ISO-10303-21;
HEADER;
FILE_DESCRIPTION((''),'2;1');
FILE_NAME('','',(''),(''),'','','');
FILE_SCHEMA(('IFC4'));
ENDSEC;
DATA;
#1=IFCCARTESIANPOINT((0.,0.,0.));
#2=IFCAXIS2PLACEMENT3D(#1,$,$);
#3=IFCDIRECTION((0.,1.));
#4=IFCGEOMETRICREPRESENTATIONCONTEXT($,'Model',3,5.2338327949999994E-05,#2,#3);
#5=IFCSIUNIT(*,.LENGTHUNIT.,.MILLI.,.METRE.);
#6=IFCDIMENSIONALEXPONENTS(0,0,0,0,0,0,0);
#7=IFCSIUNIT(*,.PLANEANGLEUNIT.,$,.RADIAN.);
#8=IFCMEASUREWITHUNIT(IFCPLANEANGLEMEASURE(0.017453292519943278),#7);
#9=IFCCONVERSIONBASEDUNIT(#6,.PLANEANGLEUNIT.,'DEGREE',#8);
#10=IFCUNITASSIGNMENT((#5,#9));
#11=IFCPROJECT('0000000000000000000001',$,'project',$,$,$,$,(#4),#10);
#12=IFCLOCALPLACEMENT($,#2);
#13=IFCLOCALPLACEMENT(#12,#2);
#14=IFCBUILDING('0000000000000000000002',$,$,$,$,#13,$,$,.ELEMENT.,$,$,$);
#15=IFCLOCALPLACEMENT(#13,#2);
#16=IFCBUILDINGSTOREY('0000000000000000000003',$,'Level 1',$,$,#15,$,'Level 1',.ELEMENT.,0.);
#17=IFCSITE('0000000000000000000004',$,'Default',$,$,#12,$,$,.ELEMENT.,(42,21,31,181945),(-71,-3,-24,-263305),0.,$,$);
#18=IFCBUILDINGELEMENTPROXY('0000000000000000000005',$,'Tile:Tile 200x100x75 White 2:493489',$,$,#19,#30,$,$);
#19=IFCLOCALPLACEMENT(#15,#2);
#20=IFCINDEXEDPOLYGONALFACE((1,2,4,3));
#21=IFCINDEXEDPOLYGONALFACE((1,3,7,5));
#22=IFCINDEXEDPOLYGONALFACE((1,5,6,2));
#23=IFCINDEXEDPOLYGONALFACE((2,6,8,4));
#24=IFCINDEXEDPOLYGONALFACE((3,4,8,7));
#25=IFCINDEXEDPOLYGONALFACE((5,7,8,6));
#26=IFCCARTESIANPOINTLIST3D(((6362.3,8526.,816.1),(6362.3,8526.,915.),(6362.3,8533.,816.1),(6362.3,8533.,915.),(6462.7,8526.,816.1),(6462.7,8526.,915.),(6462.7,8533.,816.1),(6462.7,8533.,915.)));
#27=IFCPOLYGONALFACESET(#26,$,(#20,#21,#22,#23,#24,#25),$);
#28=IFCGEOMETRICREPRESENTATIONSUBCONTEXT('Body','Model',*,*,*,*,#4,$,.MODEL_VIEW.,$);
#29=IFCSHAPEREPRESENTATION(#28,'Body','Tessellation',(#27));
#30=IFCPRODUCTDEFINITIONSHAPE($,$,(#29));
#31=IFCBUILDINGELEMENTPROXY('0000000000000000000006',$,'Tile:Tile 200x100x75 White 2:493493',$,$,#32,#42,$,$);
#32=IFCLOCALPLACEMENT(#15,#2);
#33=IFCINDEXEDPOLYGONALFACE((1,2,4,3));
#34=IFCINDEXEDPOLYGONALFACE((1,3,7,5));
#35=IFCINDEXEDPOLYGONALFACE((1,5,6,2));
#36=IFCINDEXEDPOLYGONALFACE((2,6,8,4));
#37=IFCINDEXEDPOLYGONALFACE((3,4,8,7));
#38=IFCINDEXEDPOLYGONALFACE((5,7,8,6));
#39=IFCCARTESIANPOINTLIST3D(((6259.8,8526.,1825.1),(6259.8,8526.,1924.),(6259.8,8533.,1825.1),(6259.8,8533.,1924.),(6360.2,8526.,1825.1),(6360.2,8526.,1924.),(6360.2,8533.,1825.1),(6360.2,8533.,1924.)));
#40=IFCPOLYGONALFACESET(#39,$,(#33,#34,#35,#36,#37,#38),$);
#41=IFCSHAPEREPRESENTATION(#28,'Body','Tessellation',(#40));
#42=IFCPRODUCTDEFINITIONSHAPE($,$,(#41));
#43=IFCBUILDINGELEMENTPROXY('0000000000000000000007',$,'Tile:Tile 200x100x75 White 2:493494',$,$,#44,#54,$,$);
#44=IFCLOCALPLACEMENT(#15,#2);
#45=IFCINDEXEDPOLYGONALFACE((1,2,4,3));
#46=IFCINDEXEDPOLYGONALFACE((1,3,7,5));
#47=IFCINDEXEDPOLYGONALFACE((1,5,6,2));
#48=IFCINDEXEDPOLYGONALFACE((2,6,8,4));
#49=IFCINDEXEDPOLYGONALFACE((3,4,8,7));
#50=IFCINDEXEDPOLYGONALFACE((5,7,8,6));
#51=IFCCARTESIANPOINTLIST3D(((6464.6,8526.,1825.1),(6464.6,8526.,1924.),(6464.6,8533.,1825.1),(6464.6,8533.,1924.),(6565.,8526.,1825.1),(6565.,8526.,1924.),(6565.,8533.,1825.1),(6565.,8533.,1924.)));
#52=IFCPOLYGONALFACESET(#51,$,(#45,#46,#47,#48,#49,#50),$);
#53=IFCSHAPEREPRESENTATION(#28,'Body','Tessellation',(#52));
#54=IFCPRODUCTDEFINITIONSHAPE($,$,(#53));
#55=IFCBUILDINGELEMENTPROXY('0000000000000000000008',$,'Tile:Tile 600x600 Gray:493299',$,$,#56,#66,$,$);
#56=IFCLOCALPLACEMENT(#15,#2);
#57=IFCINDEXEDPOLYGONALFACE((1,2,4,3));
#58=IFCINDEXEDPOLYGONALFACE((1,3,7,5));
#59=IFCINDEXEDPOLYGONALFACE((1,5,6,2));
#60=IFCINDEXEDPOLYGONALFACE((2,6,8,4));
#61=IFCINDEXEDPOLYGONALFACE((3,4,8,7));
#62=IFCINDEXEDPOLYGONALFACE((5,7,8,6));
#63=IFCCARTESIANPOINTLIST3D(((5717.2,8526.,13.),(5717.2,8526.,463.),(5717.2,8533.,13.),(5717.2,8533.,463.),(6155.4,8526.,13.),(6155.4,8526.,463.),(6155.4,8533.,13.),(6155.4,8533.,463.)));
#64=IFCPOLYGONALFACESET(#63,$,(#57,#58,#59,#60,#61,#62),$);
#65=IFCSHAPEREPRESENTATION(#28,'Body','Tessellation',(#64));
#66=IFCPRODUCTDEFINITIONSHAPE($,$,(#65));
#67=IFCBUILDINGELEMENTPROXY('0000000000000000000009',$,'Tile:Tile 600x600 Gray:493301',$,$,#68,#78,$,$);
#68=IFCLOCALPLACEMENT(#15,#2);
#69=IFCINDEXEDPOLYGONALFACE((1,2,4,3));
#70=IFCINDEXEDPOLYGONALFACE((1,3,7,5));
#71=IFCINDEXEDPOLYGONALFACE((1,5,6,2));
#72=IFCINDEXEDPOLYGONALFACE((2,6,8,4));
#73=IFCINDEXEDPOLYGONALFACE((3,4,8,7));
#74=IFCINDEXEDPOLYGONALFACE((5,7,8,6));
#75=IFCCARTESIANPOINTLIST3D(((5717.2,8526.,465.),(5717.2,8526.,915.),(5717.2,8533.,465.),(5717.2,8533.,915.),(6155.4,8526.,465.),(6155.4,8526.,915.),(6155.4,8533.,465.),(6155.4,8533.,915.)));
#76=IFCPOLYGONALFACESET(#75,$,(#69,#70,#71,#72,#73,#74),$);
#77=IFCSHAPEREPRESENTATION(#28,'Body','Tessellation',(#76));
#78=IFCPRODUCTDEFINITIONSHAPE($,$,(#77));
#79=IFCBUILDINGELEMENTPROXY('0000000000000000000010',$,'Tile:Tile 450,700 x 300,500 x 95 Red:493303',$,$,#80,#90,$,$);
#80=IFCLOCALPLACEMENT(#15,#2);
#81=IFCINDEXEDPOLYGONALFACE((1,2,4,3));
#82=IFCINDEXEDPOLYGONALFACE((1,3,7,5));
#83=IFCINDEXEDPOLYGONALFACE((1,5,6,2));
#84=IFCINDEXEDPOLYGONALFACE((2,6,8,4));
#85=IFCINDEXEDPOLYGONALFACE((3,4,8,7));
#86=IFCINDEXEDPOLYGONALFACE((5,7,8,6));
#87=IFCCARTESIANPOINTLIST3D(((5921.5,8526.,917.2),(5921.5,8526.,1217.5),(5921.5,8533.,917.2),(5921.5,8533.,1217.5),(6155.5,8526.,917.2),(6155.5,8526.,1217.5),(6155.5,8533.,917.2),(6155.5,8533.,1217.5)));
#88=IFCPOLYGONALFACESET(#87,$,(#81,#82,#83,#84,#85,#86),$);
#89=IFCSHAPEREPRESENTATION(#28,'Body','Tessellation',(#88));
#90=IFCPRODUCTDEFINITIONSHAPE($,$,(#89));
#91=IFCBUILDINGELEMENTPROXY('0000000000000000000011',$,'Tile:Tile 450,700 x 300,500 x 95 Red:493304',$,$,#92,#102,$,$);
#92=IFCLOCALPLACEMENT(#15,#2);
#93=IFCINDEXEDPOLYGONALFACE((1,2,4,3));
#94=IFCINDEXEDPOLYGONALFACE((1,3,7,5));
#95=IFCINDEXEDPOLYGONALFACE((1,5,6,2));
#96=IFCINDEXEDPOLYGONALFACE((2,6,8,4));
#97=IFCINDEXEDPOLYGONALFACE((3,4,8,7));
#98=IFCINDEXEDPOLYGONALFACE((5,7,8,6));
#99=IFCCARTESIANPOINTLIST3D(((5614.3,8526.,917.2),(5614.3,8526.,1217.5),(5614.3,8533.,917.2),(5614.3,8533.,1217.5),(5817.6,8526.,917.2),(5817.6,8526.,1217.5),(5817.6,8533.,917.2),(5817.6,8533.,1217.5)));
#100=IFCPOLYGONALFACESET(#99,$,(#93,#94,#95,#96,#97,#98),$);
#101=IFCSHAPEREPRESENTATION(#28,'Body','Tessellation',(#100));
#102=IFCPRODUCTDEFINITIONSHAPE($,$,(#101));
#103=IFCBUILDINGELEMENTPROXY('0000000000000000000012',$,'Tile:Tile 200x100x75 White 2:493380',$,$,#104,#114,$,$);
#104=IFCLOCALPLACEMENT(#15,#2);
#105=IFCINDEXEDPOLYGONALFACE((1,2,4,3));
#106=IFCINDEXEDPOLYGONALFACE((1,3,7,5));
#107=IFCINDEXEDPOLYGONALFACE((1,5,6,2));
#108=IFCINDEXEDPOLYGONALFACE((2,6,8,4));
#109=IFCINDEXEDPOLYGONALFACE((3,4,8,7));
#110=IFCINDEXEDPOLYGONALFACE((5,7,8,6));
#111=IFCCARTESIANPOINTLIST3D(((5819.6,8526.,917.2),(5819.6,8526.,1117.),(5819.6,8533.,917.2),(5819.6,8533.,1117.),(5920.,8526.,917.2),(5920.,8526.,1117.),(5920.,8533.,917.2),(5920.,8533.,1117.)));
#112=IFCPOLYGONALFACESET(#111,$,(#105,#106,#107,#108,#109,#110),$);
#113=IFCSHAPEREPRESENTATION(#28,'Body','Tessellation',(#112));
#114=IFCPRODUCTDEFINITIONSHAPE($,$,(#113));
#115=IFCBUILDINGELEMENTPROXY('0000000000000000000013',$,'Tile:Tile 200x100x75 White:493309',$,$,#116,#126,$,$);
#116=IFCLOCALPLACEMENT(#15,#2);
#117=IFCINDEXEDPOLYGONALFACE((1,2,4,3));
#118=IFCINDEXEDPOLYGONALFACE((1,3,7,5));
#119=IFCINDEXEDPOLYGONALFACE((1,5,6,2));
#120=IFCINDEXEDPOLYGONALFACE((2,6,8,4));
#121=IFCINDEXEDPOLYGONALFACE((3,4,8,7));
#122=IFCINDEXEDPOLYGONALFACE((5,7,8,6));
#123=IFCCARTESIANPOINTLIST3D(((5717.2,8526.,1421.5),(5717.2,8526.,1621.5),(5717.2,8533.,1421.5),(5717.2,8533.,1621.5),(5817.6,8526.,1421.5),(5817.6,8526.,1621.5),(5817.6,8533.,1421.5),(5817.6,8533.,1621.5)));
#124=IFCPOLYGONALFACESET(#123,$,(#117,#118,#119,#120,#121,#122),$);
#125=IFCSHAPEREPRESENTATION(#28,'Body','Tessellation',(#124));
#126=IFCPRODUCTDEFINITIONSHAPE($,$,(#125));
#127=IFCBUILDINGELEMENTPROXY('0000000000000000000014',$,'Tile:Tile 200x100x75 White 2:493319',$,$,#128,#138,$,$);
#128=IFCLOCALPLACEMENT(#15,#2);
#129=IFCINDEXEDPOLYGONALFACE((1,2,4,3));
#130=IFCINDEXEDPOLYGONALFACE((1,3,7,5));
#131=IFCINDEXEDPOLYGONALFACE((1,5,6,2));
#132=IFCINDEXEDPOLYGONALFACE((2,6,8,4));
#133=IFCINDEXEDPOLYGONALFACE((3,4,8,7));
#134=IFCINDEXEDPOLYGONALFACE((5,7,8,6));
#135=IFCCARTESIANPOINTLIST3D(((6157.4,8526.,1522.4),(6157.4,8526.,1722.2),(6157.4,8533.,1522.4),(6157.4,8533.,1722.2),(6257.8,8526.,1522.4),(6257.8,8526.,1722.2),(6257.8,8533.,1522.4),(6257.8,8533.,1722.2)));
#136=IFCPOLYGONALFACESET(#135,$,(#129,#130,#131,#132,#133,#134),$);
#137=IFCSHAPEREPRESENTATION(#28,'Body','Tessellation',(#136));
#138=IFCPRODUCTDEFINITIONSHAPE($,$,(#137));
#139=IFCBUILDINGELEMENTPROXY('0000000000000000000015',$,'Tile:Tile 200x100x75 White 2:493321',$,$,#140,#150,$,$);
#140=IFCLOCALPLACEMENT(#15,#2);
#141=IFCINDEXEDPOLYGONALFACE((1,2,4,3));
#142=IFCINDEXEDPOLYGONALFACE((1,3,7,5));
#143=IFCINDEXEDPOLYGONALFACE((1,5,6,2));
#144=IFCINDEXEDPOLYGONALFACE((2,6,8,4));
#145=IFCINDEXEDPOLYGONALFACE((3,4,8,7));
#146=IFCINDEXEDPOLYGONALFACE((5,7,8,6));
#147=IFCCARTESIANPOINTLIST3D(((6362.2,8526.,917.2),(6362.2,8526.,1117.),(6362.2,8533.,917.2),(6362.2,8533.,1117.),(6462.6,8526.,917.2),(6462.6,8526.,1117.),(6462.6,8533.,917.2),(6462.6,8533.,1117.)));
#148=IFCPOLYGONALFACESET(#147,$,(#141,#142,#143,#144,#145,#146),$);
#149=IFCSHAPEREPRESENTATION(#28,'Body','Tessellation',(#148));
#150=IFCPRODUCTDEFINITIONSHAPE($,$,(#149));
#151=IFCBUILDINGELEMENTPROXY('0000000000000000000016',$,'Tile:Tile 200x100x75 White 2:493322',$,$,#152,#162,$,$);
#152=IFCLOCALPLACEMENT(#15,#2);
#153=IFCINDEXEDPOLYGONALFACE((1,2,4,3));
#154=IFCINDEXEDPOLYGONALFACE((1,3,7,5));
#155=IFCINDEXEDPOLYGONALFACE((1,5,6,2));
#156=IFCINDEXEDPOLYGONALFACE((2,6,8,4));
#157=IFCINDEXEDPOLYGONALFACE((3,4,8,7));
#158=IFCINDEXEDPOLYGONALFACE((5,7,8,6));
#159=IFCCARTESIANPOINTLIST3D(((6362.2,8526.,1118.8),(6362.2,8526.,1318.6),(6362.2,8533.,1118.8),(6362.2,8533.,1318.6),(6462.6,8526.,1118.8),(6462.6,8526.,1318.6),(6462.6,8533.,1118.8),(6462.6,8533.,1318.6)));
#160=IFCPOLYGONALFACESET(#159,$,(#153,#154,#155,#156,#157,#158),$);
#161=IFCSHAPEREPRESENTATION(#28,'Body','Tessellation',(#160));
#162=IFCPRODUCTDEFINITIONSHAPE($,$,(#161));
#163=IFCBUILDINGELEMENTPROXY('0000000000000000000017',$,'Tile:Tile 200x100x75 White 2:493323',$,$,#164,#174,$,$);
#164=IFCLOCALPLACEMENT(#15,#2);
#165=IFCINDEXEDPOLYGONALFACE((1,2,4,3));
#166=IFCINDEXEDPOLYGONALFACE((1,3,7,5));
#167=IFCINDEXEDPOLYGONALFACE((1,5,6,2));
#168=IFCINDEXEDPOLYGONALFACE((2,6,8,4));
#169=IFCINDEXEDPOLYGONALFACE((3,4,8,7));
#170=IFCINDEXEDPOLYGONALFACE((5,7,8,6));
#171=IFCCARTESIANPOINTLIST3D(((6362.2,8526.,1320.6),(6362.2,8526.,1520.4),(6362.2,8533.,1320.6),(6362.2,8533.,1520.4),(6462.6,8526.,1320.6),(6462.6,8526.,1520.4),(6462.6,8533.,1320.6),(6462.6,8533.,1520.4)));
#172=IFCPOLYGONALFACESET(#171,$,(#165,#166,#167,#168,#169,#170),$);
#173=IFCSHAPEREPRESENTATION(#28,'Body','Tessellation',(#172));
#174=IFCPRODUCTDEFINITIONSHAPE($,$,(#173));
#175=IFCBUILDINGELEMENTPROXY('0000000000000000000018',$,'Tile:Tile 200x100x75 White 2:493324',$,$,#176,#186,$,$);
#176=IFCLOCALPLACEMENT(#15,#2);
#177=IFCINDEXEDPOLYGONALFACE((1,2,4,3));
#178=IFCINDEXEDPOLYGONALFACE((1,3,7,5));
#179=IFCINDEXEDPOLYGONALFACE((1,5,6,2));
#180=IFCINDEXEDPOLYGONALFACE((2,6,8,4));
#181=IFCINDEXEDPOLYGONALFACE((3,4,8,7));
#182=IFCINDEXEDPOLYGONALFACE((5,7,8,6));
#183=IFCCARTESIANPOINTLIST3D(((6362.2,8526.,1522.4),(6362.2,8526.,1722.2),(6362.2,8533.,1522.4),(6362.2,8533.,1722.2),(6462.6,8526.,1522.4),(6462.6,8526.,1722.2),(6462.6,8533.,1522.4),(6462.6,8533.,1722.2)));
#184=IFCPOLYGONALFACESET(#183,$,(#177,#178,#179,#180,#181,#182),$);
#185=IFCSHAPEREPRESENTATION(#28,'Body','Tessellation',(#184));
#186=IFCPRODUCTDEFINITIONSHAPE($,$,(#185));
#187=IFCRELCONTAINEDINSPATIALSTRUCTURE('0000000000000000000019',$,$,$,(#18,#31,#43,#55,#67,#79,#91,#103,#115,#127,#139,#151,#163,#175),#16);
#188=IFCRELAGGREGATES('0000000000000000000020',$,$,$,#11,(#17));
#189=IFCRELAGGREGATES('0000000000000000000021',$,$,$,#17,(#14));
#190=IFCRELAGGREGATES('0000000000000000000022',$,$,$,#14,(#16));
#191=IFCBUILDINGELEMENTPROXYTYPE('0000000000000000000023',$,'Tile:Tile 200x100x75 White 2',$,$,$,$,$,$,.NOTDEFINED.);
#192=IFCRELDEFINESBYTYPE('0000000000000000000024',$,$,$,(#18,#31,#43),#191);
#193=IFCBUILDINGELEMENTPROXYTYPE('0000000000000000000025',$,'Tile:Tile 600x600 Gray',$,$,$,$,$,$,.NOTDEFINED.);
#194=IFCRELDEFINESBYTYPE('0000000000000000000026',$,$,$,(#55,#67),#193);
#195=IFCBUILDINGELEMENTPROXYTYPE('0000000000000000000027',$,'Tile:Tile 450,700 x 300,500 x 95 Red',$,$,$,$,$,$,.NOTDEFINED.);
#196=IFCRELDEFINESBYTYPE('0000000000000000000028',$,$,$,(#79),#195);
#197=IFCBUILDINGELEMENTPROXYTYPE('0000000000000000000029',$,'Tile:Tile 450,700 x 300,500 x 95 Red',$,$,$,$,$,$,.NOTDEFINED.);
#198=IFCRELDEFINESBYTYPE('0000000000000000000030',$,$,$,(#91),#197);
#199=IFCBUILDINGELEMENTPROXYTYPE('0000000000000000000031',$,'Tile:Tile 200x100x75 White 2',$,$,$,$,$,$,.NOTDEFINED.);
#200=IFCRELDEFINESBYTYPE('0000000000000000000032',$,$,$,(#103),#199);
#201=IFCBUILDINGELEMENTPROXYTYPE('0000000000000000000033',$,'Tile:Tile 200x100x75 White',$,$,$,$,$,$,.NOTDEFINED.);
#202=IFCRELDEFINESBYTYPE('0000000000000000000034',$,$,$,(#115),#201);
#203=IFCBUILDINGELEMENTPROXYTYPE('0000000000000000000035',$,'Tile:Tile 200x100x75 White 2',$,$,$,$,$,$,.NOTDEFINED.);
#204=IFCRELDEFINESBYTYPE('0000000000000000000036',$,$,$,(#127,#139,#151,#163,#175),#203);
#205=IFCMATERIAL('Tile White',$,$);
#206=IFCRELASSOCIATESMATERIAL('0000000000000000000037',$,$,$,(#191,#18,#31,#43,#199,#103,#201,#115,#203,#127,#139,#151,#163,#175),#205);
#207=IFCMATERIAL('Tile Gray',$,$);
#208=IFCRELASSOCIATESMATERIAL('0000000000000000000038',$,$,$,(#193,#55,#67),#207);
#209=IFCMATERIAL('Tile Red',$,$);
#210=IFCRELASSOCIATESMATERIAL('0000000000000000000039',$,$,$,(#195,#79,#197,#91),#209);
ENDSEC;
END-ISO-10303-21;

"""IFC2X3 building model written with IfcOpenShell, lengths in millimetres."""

from ifc_helpers import new_model, entity, si_unit, converted_unit, direction, frame, frame_2d, origin, origin_2d_with_axis, place, context, subcontext, project, spatial, rectangle, extrude, source, transform, mapped, material, type_object, type_shapes, element, save


model = new_model("IFC2X3")

# Units and contexts
model_context = context("Model", 3, precision=5.2338327949999994e-05, world=origin(), true_north=direction((0.0, 1.0)))
body_context = subcontext(model_context, "Body", "Model", "MODEL_VIEW")
ifc_project = project(units=[si_unit("LENGTHUNIT", "METRE", prefix="MILLI"), converted_unit("PLANEANGLEUNIT", "DEGREE", entity("IfcPlaneAngleMeasure", 0.017453292519943278), si_unit("PLANEANGLEUNIT", "RADIAN"), dimensions=[0, 0, 0, 0, 0, 0, 0])], contexts=[model_context])

# Site, building, storey
site_placement = place(None, origin())
site = spatial("IfcSite", under=ifc_project, at=site_placement, Name="Default", CompositionType="ELEMENT", RefLatitude=(42, 21, 31, 181945), RefLongitude=(-71, -3, -24, -263305), RefElevation=0.0)
building_placement = place(site_placement, origin())
building = spatial("IfcBuilding", under=site, at=building_placement, CompositionType="ELEMENT")
storey_placement = place(building_placement, origin())
storey = spatial("IfcBuildingStorey", under=building, at=storey_placement, Name="Level 1", LongName="Level 1", CompositionType="ELEMENT", Elevation=0.0)

# Building element proxies
ifc_material_1 = material(Name="Tile White")
building_element_proxy_type_1 = type_object("IfcBuildingElementProxyType", Name="Tile:Tile 200x100x75 White 2", PredefinedType="NOTDEFINED", material=ifc_material_1)
shared_shape_1 = source(origin(), body_context, "Body", "SweptSolid", [
    extrude(rectangle(XDim=98.9, YDim=100.4, at=origin_2d_with_axis()), frame((-50.2, -49.5, 0.0), z_axis=(0.0, 0.0, 1.0), x_axis=(0.0, -1.0, 0.0)), (0.0, 0.0, 1.0), 7.0),
])
type_shapes(building_element_proxy_type_1, [shared_shape_1])
for number, where, z_axis, x_axis, name in (
    (1, (6462.7, 8533.0, 915.0), (0.0, -1.0, 0.0), (1.0, 0.0, 0.0), "Tile:Tile 200x100x75 White 2:493489"),
    (2, (6360.2, 8533.0, 1924.0), (0.0, -1.0, 0.0), (1.0, 0.0, 0.0), "Tile:Tile 200x100x75 White 2:493493"),
    (3, (6565.0, 8533.0, 1924.0), (0.0, -1.0, 0.0), (1.0, 0.0, 0.0), "Tile:Tile 200x100x75 White 2:493494"),
):
    element("IfcBuildingElementProxy", number, at=place(storey_placement, frame(where, z_axis=z_axis, x_axis=x_axis)), inside=storey, type_object=building_element_proxy_type_1, material=ifc_material_1, Name=name, context=body_context, shape_type="MappedRepresentation", body=[
        mapped(shared_shape_1, transform((0.0, 0.0, 0.0), scale=1.0)),
    ])
ifc_material_2 = material(Name="Tile Gray")
building_element_proxy_type_2 = type_object("IfcBuildingElementProxyType", Name="Tile:Tile 600x600 Gray", PredefinedType="NOTDEFINED", material=ifc_material_2)
shared_shape_2 = source(origin(), body_context, "Body", "SweptSolid", [
    extrude(rectangle(XDim=438.2, YDim=450.0, at=origin_2d_with_axis()), frame((-219.1, -225.0, 0.0), z_axis=(0.0, 0.0, 1.0), x_axis=(-1.0, 0.0, 0.0)), (0.0, 0.0, 1.0), 7.0),
])
type_shapes(building_element_proxy_type_2, [shared_shape_2])
for number, where, z_axis, x_axis, name in (
    (4, (6155.4, 8533.0, 463.0), (0.0, -1.0, 0.0), (1.0, 0.0, 0.0), "Tile:Tile 600x600 Gray:493299"),
    (5, (6155.4, 8533.0, 915.0), (0.0, -1.0, 0.0), (1.0, 0.0, 0.0), "Tile:Tile 600x600 Gray:493301"),
):
    element("IfcBuildingElementProxy", number, at=place(storey_placement, frame(where, z_axis=z_axis, x_axis=x_axis)), inside=storey, type_object=building_element_proxy_type_2, material=ifc_material_2, Name=name, context=body_context, shape_type="MappedRepresentation", body=[
        mapped(shared_shape_2, transform((0.0, 0.0, 0.0), scale=1.0)),
    ])
ifc_material_3 = material(Name="Tile Red")
building_element_proxy_type_3 = type_object("IfcBuildingElementProxyType", Name="Tile:Tile 450,700 x 300,500 x 95 Red", PredefinedType="NOTDEFINED", material=ifc_material_3)
shared_shape_3 = source(origin(), body_context, "Body", "SweptSolid", [
    extrude(rectangle(XDim=233.9, YDim=300.3, at=frame_2d((0.0, 0.0), x_axis=(1.0, 0.0))), frame((-117.0, -150.2, 0.0), z_axis=(0.0, 0.0, 1.0), x_axis=(-1.0, 0.0, 0.0)), (0.0, 0.0, 1.0), 7.0),
])
type_shapes(building_element_proxy_type_3, [shared_shape_3])
proxy_1_placement = place(storey_placement, frame((6155.5, 8533.0, 1217.5), z_axis=(0.0, -1.0, 0.0), x_axis=(1.0, 0.0, 0.0)))
element("IfcBuildingElementProxy", 6, at=proxy_1_placement, inside=storey, type_object=building_element_proxy_type_3, material=ifc_material_3, Name="Tile:Tile 450,700 x 300,500 x 95 Red:493303", context=body_context, shape_type="MappedRepresentation", body=[
    mapped(shared_shape_3, transform((0.0, 0.0, 0.0), scale=1.0)),
])
building_element_proxy_type_4 = type_object("IfcBuildingElementProxyType", Name="Tile:Tile 450,700 x 300,500 x 95 Red", PredefinedType="NOTDEFINED", material=ifc_material_3)
shared_shape_4 = source(origin(), body_context, "Body", "SweptSolid", [
    extrude(rectangle(XDim=203.3, YDim=300.3, at=frame_2d((0.0, 0.0), x_axis=(1.0, 0.0))), frame((-101.6, -150.2, 0.0), z_axis=(0.0, 0.0, 1.0), x_axis=(-1.0, 0.0, 0.0)), (0.0, 0.0, 1.0), 7.0),
])
type_shapes(building_element_proxy_type_4, [shared_shape_4])
proxy_2_placement = place(storey_placement, frame((5817.6, 8533.0, 1217.5), z_axis=(0.0, -1.0, 0.0), x_axis=(1.0, 0.0, 0.0)))
element("IfcBuildingElementProxy", 7, at=proxy_2_placement, inside=storey, type_object=building_element_proxy_type_4, material=ifc_material_3, Name="Tile:Tile 450,700 x 300,500 x 95 Red:493304", context=body_context, shape_type="MappedRepresentation", body=[
    mapped(shared_shape_4, transform((0.0, 0.0, 0.0), scale=1.0)),
])
building_element_proxy_type_5 = type_object("IfcBuildingElementProxyType", Name="Tile:Tile 200x100x75 White 2", PredefinedType="NOTDEFINED", material=ifc_material_1)
shared_shape_5 = source(origin(), body_context, "Body", "SweptSolid", [
    extrude(rectangle(XDim=199.8, YDim=100.4, at=frame_2d((0.0, 0.0), x_axis=(1.0, 0.0))), frame((-50.2, -99.9, 0.0), z_axis=(0.0, 0.0, 1.0), x_axis=(0.0, -1.0, 0.0)), (0.0, 0.0, 1.0), 7.0),
])
type_shapes(building_element_proxy_type_5, [shared_shape_5])
proxy_3_placement = place(storey_placement, frame((5920.0, 8533.0, 1117.0), z_axis=(0.0, -1.0, 0.0), x_axis=(1.0, 0.0, 0.0)))
element("IfcBuildingElementProxy", 8, at=proxy_3_placement, inside=storey, type_object=building_element_proxy_type_5, material=ifc_material_1, Name="Tile:Tile 200x100x75 White 2:493380", context=body_context, shape_type="MappedRepresentation", body=[
    mapped(shared_shape_5, transform((0.0, 0.0, 0.0), scale=1.0)),
])
building_element_proxy_type_6 = type_object("IfcBuildingElementProxyType", Name="Tile:Tile 200x100x75 White", PredefinedType="NOTDEFINED", material=ifc_material_1)
shared_shape_6 = source(origin(), body_context, "Body", "SweptSolid", [
    extrude(rectangle(XDim=200.0, YDim=100.4, at=frame_2d((0.0, 0.0), x_axis=(1.0, 0.0))), frame((-50.2, -100.0, 0.0), z_axis=(0.0, 0.0, 1.0), x_axis=(0.0, -1.0, 0.0)), (0.0, 0.0, 1.0), 7.0),
])
type_shapes(building_element_proxy_type_6, [shared_shape_6])
proxy_4_placement = place(storey_placement, frame((5817.6, 8533.0, 1621.5), z_axis=(0.0, -1.0, 0.0), x_axis=(1.0, 0.0, 0.0)))
element("IfcBuildingElementProxy", 9, at=proxy_4_placement, inside=storey, type_object=building_element_proxy_type_6, material=ifc_material_1, Name="Tile:Tile 200x100x75 White:493309", context=body_context, shape_type="MappedRepresentation", body=[
    mapped(shared_shape_6, transform((0.0, 0.0, 0.0), scale=1.0)),
])
building_element_proxy_type_7 = type_object("IfcBuildingElementProxyType", Name="Tile:Tile 200x100x75 White 2", PredefinedType="NOTDEFINED", material=ifc_material_1)
shared_shape_7 = source(origin(), body_context, "Body", "SweptSolid", [
    extrude(rectangle(XDim=199.8, YDim=100.4, at=frame_2d((0.0, 0.0), x_axis=(1.0, 0.0))), frame((-50.2, -99.9, 0.0), z_axis=(0.0, 0.0, 1.0), x_axis=(0.0, -1.0, 0.0)), (0.0, 0.0, 1.0), 7.0),
])
type_shapes(building_element_proxy_type_7, [shared_shape_7])
for number, where, z_axis, x_axis, name in (
    (10, (6257.8, 8533.0, 1722.2), (0.0, -1.0, 0.0), (1.0, 0.0, 0.0), "Tile:Tile 200x100x75 White 2:493319"),
    (11, (6462.6, 8533.0, 1117.0), (0.0, -1.0, 0.0), (1.0, 0.0, 0.0), "Tile:Tile 200x100x75 White 2:493321"),
    (12, (6462.6, 8533.0, 1318.6), (0.0, -1.0, 0.0), (1.0, 0.0, 0.0), "Tile:Tile 200x100x75 White 2:493322"),
    (13, (6462.6, 8533.0, 1520.4), (0.0, -1.0, 0.0), (1.0, 0.0, 0.0), "Tile:Tile 200x100x75 White 2:493323"),
    (14, (6462.6, 8533.0, 1722.2), (0.0, -1.0, 0.0), (1.0, 0.0, 0.0), "Tile:Tile 200x100x75 White 2:493324"),
):
    element("IfcBuildingElementProxy", number, at=place(storey_placement, frame(where, z_axis=z_axis, x_axis=x_axis)), inside=storey, type_object=building_element_proxy_type_7, material=ifc_material_1, Name=name, context=body_context, shape_type="MappedRepresentation", body=[
        mapped(shared_shape_7, transform((0.0, 0.0, 0.0), scale=1.0)),
    ])

save(model, "model.ifc")
